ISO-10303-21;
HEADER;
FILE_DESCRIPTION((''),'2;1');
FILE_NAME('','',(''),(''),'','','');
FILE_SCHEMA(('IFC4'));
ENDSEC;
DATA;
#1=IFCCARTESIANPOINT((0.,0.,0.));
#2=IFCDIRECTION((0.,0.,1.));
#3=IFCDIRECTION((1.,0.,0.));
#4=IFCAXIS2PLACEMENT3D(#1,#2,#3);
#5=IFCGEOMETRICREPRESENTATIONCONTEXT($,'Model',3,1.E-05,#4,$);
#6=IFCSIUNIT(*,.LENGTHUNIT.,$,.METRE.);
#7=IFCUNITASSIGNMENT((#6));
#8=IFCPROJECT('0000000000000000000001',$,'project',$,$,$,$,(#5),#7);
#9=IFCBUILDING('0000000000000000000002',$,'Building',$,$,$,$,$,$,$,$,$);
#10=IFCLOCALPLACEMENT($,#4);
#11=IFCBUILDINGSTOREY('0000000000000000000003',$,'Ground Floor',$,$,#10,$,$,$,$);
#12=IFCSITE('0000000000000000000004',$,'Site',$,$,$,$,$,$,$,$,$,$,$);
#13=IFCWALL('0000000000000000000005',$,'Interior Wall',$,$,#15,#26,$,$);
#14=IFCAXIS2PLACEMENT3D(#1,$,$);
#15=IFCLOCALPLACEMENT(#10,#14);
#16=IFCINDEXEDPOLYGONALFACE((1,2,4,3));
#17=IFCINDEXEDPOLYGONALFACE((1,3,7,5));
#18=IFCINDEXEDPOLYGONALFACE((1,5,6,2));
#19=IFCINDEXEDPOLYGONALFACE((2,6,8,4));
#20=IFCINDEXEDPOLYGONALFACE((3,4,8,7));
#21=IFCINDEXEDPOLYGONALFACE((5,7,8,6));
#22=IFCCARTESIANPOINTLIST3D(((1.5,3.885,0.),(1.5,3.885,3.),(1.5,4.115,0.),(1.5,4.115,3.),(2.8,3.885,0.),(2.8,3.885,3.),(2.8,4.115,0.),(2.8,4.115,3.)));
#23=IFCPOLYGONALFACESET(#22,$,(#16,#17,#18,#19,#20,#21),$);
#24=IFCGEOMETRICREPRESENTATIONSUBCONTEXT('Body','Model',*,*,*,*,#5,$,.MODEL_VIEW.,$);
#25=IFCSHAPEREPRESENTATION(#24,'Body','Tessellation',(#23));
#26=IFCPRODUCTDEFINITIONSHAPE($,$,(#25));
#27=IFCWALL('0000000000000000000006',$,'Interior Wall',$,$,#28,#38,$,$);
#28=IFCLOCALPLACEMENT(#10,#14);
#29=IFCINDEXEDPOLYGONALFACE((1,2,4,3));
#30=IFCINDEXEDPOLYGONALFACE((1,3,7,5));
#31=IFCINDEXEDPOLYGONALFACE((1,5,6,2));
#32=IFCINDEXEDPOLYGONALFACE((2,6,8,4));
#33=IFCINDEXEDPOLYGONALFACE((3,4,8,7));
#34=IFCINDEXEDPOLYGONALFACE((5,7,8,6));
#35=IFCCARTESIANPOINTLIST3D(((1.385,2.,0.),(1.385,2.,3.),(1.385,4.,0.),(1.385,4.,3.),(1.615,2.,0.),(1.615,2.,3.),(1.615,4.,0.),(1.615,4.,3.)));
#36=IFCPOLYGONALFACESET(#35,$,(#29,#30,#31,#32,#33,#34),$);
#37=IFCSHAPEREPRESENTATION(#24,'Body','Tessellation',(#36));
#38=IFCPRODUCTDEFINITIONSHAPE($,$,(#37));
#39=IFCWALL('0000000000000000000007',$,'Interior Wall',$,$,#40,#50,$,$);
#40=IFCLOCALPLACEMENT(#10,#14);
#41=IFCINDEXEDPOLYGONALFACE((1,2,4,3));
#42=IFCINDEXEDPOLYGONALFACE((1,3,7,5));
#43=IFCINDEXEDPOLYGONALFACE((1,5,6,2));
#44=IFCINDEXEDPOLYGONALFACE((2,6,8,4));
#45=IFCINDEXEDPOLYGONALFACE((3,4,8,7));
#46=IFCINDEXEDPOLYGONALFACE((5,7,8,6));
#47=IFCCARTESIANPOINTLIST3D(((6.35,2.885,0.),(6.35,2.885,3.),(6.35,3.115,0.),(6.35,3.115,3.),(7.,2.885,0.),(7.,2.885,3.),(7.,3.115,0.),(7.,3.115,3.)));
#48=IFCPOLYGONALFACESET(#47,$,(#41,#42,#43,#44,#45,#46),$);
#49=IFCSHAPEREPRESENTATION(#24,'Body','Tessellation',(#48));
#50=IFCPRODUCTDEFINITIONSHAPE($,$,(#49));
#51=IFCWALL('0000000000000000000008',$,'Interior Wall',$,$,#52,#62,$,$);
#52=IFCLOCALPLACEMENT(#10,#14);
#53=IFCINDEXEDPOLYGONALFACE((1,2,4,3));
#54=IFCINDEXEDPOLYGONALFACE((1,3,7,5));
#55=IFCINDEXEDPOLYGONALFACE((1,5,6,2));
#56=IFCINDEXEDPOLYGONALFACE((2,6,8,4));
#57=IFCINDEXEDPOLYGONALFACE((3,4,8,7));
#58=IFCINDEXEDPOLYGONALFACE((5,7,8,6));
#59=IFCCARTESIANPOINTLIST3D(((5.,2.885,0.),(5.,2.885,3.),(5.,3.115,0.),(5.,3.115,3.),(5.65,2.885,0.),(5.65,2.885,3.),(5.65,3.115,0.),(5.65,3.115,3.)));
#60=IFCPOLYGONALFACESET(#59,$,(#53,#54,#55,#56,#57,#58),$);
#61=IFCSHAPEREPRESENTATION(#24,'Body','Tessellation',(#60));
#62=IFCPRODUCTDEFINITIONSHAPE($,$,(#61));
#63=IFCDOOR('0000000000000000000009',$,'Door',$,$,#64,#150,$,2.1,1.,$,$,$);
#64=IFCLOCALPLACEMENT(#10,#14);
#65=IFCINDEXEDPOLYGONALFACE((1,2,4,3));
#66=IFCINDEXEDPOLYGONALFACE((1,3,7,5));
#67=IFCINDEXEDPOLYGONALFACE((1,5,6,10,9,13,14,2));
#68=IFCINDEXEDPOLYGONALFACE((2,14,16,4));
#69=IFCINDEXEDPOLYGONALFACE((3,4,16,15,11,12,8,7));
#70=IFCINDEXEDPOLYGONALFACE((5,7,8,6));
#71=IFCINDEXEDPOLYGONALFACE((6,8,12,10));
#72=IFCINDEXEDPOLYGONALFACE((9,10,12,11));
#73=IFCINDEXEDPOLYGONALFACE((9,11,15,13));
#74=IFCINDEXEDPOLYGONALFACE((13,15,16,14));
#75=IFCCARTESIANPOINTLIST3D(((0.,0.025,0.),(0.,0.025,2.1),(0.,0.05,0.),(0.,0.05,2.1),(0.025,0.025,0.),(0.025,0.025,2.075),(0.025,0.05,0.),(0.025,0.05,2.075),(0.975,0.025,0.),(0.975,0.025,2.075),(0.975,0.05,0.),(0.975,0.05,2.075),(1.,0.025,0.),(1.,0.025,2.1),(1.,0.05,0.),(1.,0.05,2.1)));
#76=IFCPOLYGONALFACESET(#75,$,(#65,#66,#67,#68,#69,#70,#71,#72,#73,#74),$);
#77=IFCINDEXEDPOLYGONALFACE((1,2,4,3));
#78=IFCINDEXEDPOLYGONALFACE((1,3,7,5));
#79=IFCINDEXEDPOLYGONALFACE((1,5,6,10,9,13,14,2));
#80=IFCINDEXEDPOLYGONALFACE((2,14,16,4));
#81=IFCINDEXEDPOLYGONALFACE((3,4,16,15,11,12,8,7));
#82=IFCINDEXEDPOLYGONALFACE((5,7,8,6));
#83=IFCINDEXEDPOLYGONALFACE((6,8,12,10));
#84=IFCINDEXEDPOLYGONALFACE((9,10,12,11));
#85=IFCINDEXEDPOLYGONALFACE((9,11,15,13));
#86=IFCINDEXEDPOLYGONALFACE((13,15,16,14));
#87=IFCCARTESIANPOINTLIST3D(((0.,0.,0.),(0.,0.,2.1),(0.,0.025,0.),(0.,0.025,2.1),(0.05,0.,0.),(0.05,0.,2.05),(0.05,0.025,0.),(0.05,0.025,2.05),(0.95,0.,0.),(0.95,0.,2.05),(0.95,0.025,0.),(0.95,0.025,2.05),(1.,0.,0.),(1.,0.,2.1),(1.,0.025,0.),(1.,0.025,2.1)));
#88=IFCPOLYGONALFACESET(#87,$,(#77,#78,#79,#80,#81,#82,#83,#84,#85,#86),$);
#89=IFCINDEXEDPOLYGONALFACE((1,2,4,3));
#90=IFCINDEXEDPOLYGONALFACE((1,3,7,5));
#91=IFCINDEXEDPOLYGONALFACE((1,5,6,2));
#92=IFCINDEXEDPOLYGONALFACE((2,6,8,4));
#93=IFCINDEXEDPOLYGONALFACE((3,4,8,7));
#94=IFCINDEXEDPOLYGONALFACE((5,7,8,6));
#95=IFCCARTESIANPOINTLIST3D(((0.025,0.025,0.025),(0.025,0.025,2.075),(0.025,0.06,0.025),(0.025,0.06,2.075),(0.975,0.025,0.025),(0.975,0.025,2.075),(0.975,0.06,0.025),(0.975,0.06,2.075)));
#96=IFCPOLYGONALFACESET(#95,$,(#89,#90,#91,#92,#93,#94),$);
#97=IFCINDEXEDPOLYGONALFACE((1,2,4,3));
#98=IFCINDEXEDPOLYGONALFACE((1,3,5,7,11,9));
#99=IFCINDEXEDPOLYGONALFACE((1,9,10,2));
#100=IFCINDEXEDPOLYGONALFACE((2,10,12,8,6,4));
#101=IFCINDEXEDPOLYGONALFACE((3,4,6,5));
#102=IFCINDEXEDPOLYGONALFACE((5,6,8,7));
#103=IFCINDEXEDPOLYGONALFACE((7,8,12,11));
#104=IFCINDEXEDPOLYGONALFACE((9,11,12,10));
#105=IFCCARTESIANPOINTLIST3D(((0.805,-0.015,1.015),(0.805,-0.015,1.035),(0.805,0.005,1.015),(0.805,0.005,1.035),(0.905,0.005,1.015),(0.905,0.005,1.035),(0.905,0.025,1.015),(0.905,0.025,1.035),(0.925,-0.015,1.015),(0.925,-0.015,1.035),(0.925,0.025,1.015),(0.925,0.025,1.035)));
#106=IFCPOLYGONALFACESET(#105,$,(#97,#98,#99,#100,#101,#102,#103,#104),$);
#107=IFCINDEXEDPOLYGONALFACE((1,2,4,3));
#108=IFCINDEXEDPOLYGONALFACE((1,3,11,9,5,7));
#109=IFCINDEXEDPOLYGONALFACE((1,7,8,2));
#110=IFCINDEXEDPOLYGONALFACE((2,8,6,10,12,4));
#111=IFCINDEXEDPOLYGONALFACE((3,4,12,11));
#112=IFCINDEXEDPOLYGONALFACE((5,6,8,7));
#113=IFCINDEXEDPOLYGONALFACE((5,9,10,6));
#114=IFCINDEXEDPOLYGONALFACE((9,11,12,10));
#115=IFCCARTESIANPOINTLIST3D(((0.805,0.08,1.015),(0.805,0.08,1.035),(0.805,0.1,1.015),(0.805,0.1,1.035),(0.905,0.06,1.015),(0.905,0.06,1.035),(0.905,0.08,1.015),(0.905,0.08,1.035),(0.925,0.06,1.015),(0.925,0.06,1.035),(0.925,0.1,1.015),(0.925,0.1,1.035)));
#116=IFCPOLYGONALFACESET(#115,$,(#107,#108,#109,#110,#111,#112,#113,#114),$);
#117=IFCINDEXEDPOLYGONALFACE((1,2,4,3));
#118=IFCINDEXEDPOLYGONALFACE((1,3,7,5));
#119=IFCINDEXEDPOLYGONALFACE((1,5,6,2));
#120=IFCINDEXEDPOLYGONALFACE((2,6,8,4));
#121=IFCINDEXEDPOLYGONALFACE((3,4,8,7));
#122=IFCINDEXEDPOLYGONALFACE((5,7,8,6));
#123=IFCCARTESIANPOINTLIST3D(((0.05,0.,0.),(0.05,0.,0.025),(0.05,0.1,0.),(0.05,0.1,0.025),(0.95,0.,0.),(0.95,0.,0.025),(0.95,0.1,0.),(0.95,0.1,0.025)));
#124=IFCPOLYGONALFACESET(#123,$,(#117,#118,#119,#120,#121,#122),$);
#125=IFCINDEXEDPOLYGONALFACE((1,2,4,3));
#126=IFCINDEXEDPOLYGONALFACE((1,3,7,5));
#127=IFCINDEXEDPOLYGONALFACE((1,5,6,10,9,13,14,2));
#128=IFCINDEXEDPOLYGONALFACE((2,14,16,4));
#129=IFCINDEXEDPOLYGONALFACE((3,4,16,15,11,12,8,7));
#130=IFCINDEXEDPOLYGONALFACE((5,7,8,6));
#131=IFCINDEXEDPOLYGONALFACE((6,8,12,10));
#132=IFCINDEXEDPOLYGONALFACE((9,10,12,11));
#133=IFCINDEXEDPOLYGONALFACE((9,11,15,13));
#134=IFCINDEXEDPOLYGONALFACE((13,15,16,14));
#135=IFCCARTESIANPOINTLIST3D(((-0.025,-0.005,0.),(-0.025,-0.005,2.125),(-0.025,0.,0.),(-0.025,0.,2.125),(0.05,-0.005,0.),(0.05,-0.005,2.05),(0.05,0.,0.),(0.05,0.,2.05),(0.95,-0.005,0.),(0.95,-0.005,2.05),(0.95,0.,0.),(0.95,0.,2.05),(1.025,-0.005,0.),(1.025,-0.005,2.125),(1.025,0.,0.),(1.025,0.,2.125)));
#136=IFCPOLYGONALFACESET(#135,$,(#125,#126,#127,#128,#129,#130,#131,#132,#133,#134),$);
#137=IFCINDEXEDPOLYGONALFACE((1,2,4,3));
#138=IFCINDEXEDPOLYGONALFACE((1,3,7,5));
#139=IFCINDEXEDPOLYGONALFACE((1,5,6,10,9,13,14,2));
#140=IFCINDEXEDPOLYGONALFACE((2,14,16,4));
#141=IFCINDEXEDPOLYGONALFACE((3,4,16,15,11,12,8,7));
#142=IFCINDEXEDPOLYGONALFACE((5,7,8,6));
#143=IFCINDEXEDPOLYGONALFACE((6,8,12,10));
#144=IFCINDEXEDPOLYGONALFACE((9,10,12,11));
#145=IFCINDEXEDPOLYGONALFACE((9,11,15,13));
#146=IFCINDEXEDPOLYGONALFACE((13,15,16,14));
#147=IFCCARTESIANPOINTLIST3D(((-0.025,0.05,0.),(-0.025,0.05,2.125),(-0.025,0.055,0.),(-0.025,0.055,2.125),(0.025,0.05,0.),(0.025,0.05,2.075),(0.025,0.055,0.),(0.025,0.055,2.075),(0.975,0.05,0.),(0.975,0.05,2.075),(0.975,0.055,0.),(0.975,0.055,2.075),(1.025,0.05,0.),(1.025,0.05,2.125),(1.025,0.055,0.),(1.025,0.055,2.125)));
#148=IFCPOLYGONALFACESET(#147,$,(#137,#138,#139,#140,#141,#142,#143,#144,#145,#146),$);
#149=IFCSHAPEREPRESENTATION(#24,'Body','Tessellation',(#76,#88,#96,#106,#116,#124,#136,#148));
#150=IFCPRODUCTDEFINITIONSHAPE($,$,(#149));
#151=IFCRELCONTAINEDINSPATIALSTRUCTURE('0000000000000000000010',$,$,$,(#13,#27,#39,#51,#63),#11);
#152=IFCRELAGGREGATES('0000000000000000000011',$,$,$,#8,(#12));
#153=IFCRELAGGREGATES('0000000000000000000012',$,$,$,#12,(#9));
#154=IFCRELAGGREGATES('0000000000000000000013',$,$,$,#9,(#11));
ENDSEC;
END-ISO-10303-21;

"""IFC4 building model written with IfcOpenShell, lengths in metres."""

from ifc_helpers import new_model, si_unit, frame, origin_with_axes, place, context, subcontext, project, spatial, line, indexed_curve, outline, extrude, element, save


model = new_model("IFC4")

# Units and contexts
model_context = context("Model", 3, precision=1e-05, world=origin_with_axes())
body_context = subcontext(model_context, "Body", "Model", "MODEL_VIEW")
ifc_project = project(units=[si_unit("LENGTHUNIT", "METRE")], contexts=[model_context])

# Site, building, storey
site = spatial("IfcSite", under=ifc_project, Name="Site")
building = spatial("IfcBuilding", under=site, Name="Building")
storey_placement = place(None, origin_with_axes())
storey = spatial("IfcBuildingStorey", under=building, at=storey_placement, Name="Ground Floor")

# Walls
for number, where, z_axis, x_axis, name in (
    (1, (2.8, 4.0, 0.0), (0.0, 0.0, 1.0), (-1.0, 0.0, 0.0), "Interior Wall"),
):
    element("IfcWall", number, at=place(storey_placement, frame(where, z_axis=z_axis, x_axis=x_axis)), inside=storey, Name=name, context=body_context, shape_type="SweptSolid", body=[
        extrude(outline(indexed_curve([(0.0, 0.0), (0.0, 0.23), (1.3, 0.23), (1.3, 0.0), (0.0, 0.0)], self_intersect=False)), frame((0.0, -0.115, 0.0), z_axis=(0.0, 0.0, 1.0), x_axis=(1.0, 0.0, 0.0)), (0.0, 0.0, 1.0), 3.0),
    ])
wall_1_placement = place(storey_placement, frame((1.5, 4.0, 0.0), z_axis=(0.0, 0.0, 1.0), x_axis=(0.0, -1.0, 0.0)))
element("IfcWall", 2, at=wall_1_placement, inside=storey, Name="Interior Wall", context=body_context, shape_type="SweptSolid", body=[
    extrude(outline(indexed_curve([(0.0, 0.0), (0.0, 0.23), (2.0, 0.23), (2.0, 0.0), (0.0, 0.0)], self_intersect=False)), frame((0.0, -0.115, 0.0), z_axis=(0.0, 0.0, 1.0), x_axis=(1.0, 0.0, 0.0)), (0.0, 0.0, 1.0), 3.0),
])
for number, where, z_axis, x_axis, name in (
    (3, (7.0, 3.0, 0.0), (0.0, 0.0, 1.0), (-1.0, 0.0, 0.0), "Interior Wall"),
    (4, (5.65, 3.0, 0.0), (0.0, 0.0, 1.0), (-1.0, 0.0, 0.0), "Interior Wall"),
):
    element("IfcWall", number, at=place(storey_placement, frame(where, z_axis=z_axis, x_axis=x_axis)), inside=storey, Name=name, context=body_context, shape_type="SweptSolid", body=[
        extrude(outline(indexed_curve([(0.0, 0.0), (0.0, 0.23), (0.65, 0.23), (0.65, 0.0), (0.0, 0.0)], self_intersect=False)), frame((0.0, -0.115, 0.0), z_axis=(0.0, 0.0, 1.0), x_axis=(1.0, 0.0, 0.0)), (0.0, 0.0, 1.0), 3.0),
    ])

# Door
door_1_placement = place(storey_placement, origin_with_axes())
element("IfcDoor", 5, at=door_1_placement, inside=storey, Name="Door", OverallHeight=2.1, OverallWidth=1.0, context=body_context, shape_type="SweptSolid", body=[
    extrude(outline(indexed_curve([(0.0, 0.0), (0.0, 2.1), (1.0, 2.1), (1.0, 0.0), (0.975, 0.0), (0.975, 2.075), (0.025, 2.075), (0.025, 0.0)], segments=[line(1, 2, 3, 4, 5, 6, 7, 8, 1)])), frame((0.0, 0.025, 0.0), z_axis=(0.0, -1.0, 0.0), x_axis=(1.0, 0.0, 0.0)), (0.0, 0.0, -1.0), 0.025),
    extrude(outline(indexed_curve([(0.0, 0.0), (0.0, 2.1), (1.0, 2.1), (1.0, 0.0), (0.95, 0.0), (0.95, 2.05), (0.05, 2.05), (0.05, 0.0)], segments=[line(1, 2, 3, 4, 5, 6, 7, 8, 1)])), frame((0.0, 0.0, 0.0), z_axis=(0.0, -1.0, 0.0), x_axis=(1.0, 0.0, 0.0)), (0.0, 0.0, -1.0), 0.025),
    extrude(outline(indexed_curve([(0.0, 0.0), (0.95, 0.0), (0.95, 0.035), (0.0, 0.035)], segments=[line(1, 2, 3, 4, 1)])), frame((0.025, 0.025, 0.025), z_axis=(0.0, 0.0, 1.0), x_axis=(1.0, 0.0, 0.0)), (0.0, 0.0, 1.0), 2.05),
    extrude(outline(indexed_curve([(0.0, 0.0), (0.0, -0.04), (-0.12, -0.04), (-0.12, -0.02), (-0.02, -0.02), (-0.02, 0.0)], segments=[line(1, 2, 3, 4, 5, 6, 1)])), frame((0.925, 0.025, 1.015), z_axis=(0.0, 0.0, 1.0), x_axis=(1.0, 0.0, 0.0)), (0.0, 0.0, 1.0), 0.02),
    extrude(outline(indexed_curve([(0.0, 0.0), (0.0, 0.04), (-0.12, 0.04), (-0.12, 0.02), (-0.02, 0.02), (-0.02, 0.0)], segments=[line(1, 2, 3, 4, 5, 6, 1)])), frame((0.925, 0.06, 1.015), z_axis=(0.0, 0.0, 1.0), x_axis=(1.0, 0.0, 0.0)), (0.0, 0.0, 1.0), 0.02),
    extrude(outline(indexed_curve([(0.0, 0.0), (0.9, 0.0), (0.9, 0.1), (0.0, 0.1)], segments=[line(1, 2, 3, 4, 1)])), frame((0.05, 0.0, 0.0), z_axis=(0.0, 0.0, 1.0), x_axis=(1.0, 0.0, 0.0)), (0.0, 0.0, 1.0), 0.025),
    extrude(outline(indexed_curve([(0.0, 0.0), (0.0, 2.125), (1.05, 2.125), (1.05, 0.0), (0.975, 0.0), (0.975, 2.05), (0.075, 2.05), (0.075, 0.0)], segments=[line(1, 2, 3, 4, 5, 6, 7, 8, 1)])), frame((-0.025, -0.005, 0.0), z_axis=(0.0, -1.0, 0.0), x_axis=(1.0, 0.0, 0.0)), (0.0, 0.0, -1.0), 0.005),
    extrude(outline(indexed_curve([(0.0, 0.0), (0.0, 2.125), (1.05, 2.125), (1.05, 0.0), (1.0, 0.0), (1.0, 2.075), (0.05, 2.075), (0.05, 0.0)], segments=[line(1, 2, 3, 4, 5, 6, 7, 8, 1)])), frame((-0.025, 0.05, 0.0), z_axis=(0.0, -1.0, 0.0), x_axis=(1.0, 0.0, 0.0)), (0.0, 0.0, -1.0), 0.005),
])

save(model, "model.ifc")
